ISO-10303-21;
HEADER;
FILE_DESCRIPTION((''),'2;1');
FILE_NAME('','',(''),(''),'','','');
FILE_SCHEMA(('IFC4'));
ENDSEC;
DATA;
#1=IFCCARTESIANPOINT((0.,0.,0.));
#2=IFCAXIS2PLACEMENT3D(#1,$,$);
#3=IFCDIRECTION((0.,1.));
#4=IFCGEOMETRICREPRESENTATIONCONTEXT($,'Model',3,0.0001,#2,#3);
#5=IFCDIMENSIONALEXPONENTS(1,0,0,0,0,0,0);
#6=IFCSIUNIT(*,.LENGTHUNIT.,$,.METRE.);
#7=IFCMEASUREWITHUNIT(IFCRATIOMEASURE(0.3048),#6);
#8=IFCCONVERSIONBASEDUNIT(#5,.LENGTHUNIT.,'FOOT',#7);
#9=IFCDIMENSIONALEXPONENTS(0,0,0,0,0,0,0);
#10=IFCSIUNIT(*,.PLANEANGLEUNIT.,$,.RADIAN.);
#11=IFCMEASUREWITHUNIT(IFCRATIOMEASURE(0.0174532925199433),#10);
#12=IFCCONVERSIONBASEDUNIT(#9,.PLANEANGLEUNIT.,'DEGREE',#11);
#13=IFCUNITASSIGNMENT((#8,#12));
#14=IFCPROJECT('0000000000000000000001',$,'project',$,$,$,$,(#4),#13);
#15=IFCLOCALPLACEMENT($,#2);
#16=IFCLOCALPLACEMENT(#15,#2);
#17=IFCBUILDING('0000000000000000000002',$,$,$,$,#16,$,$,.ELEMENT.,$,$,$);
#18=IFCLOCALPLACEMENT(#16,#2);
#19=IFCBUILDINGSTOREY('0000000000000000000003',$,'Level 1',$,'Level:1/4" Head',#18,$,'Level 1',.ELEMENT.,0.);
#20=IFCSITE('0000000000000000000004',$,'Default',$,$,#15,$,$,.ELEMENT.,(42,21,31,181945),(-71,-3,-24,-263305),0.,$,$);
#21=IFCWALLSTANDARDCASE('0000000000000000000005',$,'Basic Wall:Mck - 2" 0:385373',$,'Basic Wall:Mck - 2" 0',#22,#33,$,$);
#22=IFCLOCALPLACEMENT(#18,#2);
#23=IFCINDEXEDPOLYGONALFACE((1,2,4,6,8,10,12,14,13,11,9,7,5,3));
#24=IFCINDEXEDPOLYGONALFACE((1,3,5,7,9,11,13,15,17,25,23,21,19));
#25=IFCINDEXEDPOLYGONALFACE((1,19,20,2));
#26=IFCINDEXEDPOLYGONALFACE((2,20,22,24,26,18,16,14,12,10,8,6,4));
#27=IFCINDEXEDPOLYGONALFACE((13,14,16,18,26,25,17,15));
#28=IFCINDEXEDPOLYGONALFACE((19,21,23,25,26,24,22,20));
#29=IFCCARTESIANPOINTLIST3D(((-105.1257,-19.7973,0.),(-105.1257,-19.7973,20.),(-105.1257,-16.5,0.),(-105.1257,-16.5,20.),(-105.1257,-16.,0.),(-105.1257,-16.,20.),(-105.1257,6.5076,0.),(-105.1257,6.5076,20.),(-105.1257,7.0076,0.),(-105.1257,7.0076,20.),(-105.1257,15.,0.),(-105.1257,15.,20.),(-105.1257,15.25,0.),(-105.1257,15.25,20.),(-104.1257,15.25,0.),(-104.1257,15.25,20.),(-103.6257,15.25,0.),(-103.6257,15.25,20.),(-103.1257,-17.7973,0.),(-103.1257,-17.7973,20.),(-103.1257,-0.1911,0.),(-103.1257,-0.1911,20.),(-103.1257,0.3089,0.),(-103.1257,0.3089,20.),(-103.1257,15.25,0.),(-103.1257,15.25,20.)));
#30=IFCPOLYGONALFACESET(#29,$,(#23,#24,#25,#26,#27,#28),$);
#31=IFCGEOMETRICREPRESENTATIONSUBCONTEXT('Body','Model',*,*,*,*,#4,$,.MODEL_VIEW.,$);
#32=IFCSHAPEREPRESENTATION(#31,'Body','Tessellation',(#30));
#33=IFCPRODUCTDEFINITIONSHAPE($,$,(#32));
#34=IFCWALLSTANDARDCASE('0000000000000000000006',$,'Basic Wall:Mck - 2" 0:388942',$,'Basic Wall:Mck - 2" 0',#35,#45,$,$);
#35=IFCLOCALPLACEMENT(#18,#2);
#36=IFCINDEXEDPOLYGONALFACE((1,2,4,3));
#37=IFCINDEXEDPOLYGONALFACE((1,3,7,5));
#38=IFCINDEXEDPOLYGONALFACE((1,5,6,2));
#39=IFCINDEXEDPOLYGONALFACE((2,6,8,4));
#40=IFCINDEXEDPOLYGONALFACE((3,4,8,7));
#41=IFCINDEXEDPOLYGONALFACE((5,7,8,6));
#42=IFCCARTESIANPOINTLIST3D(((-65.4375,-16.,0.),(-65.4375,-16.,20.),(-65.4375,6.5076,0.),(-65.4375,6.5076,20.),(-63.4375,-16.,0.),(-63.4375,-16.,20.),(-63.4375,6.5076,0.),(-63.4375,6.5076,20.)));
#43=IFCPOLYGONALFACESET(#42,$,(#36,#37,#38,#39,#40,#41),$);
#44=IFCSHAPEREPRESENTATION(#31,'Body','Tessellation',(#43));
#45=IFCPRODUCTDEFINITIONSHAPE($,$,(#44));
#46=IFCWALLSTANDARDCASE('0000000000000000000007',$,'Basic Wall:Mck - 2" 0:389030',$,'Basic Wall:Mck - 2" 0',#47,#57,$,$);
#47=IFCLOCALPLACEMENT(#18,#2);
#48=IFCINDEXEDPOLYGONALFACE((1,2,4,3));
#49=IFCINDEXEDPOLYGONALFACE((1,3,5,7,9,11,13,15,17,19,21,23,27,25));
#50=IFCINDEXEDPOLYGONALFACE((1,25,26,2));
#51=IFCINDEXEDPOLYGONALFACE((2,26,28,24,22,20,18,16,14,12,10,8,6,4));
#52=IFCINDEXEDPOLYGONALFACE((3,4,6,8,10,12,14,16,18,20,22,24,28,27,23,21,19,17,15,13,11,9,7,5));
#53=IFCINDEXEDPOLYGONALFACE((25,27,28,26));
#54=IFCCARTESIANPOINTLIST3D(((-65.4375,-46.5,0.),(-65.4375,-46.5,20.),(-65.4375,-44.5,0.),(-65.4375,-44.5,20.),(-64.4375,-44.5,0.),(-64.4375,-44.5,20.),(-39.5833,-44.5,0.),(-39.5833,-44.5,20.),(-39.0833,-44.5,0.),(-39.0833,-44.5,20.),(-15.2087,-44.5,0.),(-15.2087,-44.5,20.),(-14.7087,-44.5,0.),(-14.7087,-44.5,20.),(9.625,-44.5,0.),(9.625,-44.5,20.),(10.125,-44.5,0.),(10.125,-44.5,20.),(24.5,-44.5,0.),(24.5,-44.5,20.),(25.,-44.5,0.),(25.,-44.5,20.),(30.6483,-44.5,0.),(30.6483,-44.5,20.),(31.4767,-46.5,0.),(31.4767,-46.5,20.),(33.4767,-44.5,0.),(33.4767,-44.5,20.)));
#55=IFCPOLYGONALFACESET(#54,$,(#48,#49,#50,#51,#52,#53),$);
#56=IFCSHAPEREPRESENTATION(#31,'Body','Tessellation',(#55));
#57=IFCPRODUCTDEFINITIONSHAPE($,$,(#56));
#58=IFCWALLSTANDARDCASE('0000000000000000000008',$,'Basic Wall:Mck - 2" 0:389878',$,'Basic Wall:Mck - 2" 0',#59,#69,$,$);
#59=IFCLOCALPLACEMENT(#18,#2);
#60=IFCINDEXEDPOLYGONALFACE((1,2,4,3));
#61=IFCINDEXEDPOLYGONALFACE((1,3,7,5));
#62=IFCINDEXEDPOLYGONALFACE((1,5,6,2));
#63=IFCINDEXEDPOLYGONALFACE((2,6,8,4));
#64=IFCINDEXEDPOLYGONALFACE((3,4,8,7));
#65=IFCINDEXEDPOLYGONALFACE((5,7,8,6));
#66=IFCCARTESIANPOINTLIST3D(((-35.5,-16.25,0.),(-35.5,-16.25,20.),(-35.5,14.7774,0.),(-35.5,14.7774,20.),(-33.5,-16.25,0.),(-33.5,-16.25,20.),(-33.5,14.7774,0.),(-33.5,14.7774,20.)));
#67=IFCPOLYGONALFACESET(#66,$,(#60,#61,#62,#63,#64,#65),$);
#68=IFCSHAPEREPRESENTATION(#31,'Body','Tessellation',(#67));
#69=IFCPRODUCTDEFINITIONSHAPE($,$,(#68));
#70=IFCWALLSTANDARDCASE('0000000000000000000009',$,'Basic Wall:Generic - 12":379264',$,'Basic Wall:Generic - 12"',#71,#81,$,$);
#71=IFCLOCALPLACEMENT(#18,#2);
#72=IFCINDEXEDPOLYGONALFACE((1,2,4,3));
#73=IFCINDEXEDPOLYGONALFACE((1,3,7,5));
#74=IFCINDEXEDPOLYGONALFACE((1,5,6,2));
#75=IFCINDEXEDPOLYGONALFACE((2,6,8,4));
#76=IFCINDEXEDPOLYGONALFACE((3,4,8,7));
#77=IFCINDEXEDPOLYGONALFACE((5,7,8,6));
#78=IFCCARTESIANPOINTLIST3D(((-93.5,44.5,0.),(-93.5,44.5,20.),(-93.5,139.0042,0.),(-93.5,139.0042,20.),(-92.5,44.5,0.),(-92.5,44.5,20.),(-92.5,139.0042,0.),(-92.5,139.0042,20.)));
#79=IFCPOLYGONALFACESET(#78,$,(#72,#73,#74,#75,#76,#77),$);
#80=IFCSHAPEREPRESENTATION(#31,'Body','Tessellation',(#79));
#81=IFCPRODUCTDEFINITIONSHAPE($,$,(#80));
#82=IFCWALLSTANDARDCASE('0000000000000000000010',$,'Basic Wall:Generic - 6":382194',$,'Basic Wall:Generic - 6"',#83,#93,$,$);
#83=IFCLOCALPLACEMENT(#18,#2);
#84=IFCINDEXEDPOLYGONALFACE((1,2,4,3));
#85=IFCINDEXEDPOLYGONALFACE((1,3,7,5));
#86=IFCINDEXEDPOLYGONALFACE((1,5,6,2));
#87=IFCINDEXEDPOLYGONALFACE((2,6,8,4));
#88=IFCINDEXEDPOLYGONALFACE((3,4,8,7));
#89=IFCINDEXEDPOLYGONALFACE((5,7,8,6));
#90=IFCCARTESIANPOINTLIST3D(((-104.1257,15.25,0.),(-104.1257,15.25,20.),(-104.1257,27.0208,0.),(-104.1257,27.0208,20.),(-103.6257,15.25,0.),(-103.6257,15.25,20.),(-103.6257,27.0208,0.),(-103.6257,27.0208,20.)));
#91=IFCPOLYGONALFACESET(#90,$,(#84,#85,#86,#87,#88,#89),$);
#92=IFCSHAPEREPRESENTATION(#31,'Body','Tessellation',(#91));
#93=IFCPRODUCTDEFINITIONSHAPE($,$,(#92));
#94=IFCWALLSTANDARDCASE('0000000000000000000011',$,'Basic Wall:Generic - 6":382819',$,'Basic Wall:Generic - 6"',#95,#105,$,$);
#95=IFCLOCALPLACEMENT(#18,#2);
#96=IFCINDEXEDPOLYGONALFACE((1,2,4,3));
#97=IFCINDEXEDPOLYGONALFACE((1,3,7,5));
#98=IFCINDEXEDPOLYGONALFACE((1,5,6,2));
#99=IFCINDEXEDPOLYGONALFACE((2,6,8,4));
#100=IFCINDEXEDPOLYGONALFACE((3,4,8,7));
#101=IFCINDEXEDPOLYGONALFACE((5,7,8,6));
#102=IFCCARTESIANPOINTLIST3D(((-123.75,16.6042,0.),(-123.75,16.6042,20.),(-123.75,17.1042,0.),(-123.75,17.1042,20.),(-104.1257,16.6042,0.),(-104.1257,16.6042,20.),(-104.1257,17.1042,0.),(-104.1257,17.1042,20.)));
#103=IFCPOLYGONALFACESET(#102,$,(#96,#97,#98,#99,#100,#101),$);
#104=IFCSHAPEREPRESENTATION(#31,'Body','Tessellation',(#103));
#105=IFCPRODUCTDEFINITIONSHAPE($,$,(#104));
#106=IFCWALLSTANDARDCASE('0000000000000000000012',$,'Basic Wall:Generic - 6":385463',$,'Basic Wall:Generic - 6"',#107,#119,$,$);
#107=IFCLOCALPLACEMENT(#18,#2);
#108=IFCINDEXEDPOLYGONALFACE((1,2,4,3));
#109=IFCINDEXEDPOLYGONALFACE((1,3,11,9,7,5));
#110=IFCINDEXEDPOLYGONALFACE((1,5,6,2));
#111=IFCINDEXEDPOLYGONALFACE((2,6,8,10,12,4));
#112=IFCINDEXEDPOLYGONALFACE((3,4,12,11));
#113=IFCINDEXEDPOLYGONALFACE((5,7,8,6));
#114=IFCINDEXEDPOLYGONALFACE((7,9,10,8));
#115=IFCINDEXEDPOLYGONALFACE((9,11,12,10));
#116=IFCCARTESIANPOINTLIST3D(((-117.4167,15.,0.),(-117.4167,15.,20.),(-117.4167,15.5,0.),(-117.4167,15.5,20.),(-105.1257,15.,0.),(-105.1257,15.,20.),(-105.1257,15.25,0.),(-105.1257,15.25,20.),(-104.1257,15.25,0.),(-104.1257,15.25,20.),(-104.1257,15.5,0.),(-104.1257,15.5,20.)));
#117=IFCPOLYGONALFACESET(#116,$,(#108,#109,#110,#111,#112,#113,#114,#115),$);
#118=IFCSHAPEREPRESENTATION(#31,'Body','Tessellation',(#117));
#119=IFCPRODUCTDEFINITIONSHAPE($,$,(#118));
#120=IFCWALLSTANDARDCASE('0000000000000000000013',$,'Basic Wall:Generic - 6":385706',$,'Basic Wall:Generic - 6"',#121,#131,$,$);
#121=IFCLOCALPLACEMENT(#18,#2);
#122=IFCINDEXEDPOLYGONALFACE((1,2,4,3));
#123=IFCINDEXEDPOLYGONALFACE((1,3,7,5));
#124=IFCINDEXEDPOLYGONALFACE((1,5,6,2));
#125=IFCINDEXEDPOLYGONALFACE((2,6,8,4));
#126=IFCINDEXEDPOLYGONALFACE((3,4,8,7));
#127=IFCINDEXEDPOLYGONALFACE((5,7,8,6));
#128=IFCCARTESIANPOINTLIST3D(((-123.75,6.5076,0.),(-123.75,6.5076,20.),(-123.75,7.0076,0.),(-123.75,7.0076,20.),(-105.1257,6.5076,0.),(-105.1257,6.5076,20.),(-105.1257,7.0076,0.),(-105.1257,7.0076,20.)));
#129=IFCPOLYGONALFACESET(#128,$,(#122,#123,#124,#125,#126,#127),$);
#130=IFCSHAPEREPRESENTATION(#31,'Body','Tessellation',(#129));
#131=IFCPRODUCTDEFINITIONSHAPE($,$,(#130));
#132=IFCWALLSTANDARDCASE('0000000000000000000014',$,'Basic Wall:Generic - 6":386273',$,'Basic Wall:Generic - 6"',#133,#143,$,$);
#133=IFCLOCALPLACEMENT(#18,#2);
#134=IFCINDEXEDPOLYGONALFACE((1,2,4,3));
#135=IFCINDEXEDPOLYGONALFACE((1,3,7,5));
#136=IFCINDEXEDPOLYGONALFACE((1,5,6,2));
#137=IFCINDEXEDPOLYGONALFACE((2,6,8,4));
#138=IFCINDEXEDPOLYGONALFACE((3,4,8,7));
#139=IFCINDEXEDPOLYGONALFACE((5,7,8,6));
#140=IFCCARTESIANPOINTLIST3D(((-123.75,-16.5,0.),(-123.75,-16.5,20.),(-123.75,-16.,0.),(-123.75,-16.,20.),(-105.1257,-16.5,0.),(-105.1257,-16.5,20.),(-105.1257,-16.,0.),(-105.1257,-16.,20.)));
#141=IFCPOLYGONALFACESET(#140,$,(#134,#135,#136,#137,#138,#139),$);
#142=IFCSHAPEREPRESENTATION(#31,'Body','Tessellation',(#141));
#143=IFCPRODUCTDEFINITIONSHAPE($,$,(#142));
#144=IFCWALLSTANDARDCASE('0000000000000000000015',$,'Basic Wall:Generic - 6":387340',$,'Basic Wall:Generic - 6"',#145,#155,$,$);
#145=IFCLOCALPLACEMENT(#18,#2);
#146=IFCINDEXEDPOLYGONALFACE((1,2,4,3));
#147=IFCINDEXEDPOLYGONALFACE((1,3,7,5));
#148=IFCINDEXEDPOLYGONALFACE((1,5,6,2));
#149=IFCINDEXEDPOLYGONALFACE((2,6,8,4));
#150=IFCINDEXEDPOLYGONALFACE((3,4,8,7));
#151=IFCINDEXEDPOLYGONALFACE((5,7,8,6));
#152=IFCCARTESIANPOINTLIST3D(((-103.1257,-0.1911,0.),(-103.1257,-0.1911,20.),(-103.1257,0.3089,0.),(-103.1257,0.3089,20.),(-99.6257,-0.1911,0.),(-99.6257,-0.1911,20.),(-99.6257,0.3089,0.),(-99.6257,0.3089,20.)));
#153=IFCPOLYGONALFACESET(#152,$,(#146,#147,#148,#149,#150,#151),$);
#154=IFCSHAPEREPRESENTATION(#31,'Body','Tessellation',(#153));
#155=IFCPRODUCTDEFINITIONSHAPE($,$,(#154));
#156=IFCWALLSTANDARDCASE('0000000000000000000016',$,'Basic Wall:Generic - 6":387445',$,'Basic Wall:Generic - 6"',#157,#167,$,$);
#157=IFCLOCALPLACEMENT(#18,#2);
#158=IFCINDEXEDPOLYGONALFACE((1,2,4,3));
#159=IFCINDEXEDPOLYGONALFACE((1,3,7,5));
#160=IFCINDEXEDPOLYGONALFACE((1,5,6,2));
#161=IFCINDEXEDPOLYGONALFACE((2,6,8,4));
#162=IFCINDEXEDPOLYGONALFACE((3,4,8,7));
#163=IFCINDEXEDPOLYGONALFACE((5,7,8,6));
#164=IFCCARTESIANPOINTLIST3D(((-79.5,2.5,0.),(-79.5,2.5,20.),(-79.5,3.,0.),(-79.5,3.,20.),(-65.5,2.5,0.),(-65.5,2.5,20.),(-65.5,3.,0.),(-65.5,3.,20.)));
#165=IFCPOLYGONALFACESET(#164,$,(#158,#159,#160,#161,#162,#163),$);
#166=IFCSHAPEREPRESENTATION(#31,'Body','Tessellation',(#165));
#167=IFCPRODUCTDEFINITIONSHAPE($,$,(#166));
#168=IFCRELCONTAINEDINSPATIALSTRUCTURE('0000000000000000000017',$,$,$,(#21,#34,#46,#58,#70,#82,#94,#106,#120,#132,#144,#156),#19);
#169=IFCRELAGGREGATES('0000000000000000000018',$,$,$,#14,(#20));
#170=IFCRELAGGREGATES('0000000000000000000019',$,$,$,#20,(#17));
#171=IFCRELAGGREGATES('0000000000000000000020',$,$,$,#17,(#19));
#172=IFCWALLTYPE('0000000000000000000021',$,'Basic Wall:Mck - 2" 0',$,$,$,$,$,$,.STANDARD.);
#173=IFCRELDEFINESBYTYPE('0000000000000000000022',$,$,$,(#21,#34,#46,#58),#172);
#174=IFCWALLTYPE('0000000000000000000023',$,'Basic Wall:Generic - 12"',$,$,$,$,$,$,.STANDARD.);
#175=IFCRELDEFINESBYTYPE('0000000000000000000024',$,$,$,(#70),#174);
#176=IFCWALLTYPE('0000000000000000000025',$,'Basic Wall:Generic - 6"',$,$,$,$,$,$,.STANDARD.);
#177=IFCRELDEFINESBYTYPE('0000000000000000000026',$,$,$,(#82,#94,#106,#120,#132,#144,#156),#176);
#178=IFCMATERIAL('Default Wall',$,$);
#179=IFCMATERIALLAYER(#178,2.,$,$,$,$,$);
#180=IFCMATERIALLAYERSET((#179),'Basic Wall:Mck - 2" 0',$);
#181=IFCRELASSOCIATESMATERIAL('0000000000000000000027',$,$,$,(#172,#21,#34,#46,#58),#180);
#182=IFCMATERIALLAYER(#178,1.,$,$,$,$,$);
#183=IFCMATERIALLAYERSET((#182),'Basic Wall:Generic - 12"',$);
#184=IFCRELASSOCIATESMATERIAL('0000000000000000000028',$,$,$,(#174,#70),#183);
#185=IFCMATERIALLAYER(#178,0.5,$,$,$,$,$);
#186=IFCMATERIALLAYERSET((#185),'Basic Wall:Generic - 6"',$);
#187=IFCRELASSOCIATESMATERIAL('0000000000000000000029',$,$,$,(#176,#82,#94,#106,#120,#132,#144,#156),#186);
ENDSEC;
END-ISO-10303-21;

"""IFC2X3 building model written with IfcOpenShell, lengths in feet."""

from ifc_helpers import new_model, entity, si_unit, converted_unit, direction, frame, frame_2d, origin, place, context, subcontext, project, spatial, polyline, rectangle, outline, extrude, material, layer, layer_set, layer_usage, type_object, element, save


model = new_model("IFC2X3")

# Units and contexts
model_context = context("Model", 3, precision=0.0001, world=origin(), true_north=direction((0.0, 1.0)))
body_context = subcontext(model_context, "Body", "Model", "MODEL_VIEW")
ifc_project = project(units=[converted_unit("LENGTHUNIT", "FOOT", entity("IfcRatioMeasure", 0.3048), si_unit("LENGTHUNIT", "METRE"), dimensions=[1, 0, 0, 0, 0, 0, 0]), converted_unit("PLANEANGLEUNIT", "DEGREE", entity("IfcRatioMeasure", 0.0174532925199433), si_unit("PLANEANGLEUNIT", "RADIAN"), dimensions=[0, 0, 0, 0, 0, 0, 0])], contexts=[model_context])

# Site, building, storey
site_placement = place(None, origin())
site = spatial("IfcSite", under=ifc_project, at=site_placement, Name="Default", CompositionType="ELEMENT", RefLatitude=(42, 21, 31, 181945), RefLongitude=(-71, -3, -24, -263305), RefElevation=0.0)
building_placement = place(site_placement, origin())
building = spatial("IfcBuilding", under=site, at=building_placement, CompositionType="ELEMENT")
storey_placement = place(building_placement, origin())
storey = spatial("IfcBuildingStorey", under=building, at=storey_placement, Name="Level 1", ObjectType="Level:1/4\" Head", LongName="Level 1", CompositionType="ELEMENT", Elevation=0.0)

# Walls
ifc_material = material(Name="Default Wall")
ifc_layer_1 = layer(ifc_material, 2.0)
ifc_layer_set_1 = layer_set([ifc_layer_1], Name="Basic Wall:Mck - 2\" 0")
ifc_layer_usage_1 = layer_usage(ifc_layer_set_1, "AXIS2", "NEGATIVE", 1.0)
wall_type_1 = type_object("IfcWallType", Name="Basic Wall:Mck - 2\" 0", PredefinedType="STANDARD", material=ifc_layer_set_1)
wall_1_placement = place(storey_placement, frame((-104.1257, 15.25, 0.0), z_axis=(0.0, 0.0, 1.0), x_axis=(0.0, -1.0, 0.0)))
element("IfcWallStandardCase", 1, at=wall_1_placement, inside=storey, type_object=wall_type_1, material=ifc_layer_usage_1, Name="Basic Wall:Mck - 2\" 0:385373", ObjectType="Basic Wall:Mck - 2\" 0", context=body_context, shape_type="SweptSolid", body=[
    extrude(outline(polyline([(35.0473, -1.0), (33.0473, 1.0), (15.4411, 1.0), (14.9411, 1.0), (0.0, 1.0), (0.0, 0.5), (0.0, 0.0), (0.0, -1.0), (0.25, -1.0), (8.2424, -1.0), (8.7424, -1.0), (31.25, -1.0), (31.75, -1.0), (35.0473, -1.0)])), origin(), (0.0, 0.0, 1.0), 20.0),
])
ifc_layer_usage_2 = layer_usage(ifc_layer_set_1, "AXIS2", "NEGATIVE", 1.0)
wall_2_placement = place(storey_placement, frame((-64.4375, 6.5076, 0.0), z_axis=(0.0, 0.0, 1.0), x_axis=(0.0, -1.0, 0.0)))
element("IfcWallStandardCase", 2, at=wall_2_placement, inside=storey, type_object=wall_type_1, material=ifc_layer_usage_2, Name="Basic Wall:Mck - 2\" 0:388942", ObjectType="Basic Wall:Mck - 2\" 0", context=body_context, shape_type="SweptSolid", body=[
    extrude(rectangle(XDim=22.5076, YDim=2.0, at=frame_2d((11.2538, 0.0), x_axis=(-1.0, 0.0))), origin(), (0.0, 0.0, 1.0), 20.0),
])
ifc_layer_usage_3 = layer_usage(ifc_layer_set_1, "AXIS2", "NEGATIVE", 1.0)
wall_3_placement = place(storey_placement, frame((-65.4375, -45.5, 0.0)))
element("IfcWallStandardCase", 3, at=wall_3_placement, inside=storey, type_object=wall_type_1, material=ifc_layer_usage_3, Name="Basic Wall:Mck - 2\" 0:389030", ObjectType="Basic Wall:Mck - 2\" 0", context=body_context, shape_type="SweptSolid", body=[
    extrude(outline(polyline([(96.9142, -1.0), (98.9142, 1.0), (96.0858, 1.0), (90.4375, 1.0), (89.9375, 1.0), (75.5625, 1.0), (75.0625, 1.0), (50.7288, 1.0), (50.2288, 1.0), (26.3542, 1.0), (25.8542, 1.0), (1.0, 1.0), (0.0, 1.0), (0.0, -1.0), (96.9142, -1.0)])), origin(), (0.0, 0.0, 1.0), 20.0),
])
ifc_layer_usage_4 = layer_usage(ifc_layer_set_1, "AXIS2", "NEGATIVE", 1.0)
wall_4_placement = place(storey_placement, frame((-34.5, 14.7774, 0.0), z_axis=(0.0, 0.0, 1.0), x_axis=(0.0, -1.0, 0.0)))
element("IfcWallStandardCase", 4, at=wall_4_placement, inside=storey, type_object=wall_type_1, material=ifc_layer_usage_4, Name="Basic Wall:Mck - 2\" 0:389878", ObjectType="Basic Wall:Mck - 2\" 0", context=body_context, shape_type="SweptSolid", body=[
    extrude(rectangle(XDim=31.0274, YDim=2.0, at=frame_2d((15.5137, 0.0), x_axis=(-1.0, 0.0))), origin(), (0.0, 0.0, 1.0), 20.0),
])
ifc_layer_2 = layer(ifc_material, 1.0)
ifc_layer_set_2 = layer_set([ifc_layer_2], Name="Basic Wall:Generic - 12\"")
ifc_layer_usage_5 = layer_usage(ifc_layer_set_2, "AXIS2", "NEGATIVE", 0.5)
wall_type_2 = type_object("IfcWallType", Name="Basic Wall:Generic - 12\"", PredefinedType="STANDARD", material=ifc_layer_set_2)
wall_5_placement = place(storey_placement, frame((-93.0, 44.5, 0.0), z_axis=(0.0, 0.0, 1.0), x_axis=(0.0, 1.0, 0.0)))
element("IfcWallStandardCase", 5, at=wall_5_placement, inside=storey, type_object=wall_type_2, material=ifc_layer_usage_5, Name="Basic Wall:Generic - 12\":379264", ObjectType="Basic Wall:Generic - 12\"", context=body_context, shape_type="SweptSolid", body=[
    extrude(rectangle(XDim=94.5042, YDim=1.0, at=frame_2d((47.2521, 0.0), x_axis=(-1.0, 0.0))), origin(), (0.0, 0.0, 1.0), 20.0),
])
ifc_layer_3 = layer(ifc_material, 0.5)
ifc_layer_set_3 = layer_set([ifc_layer_3], Name="Basic Wall:Generic - 6\"")
ifc_layer_usage_6 = layer_usage(ifc_layer_set_3, "AXIS2", "NEGATIVE", 0.25)
wall_type_3 = type_object("IfcWallType", Name="Basic Wall:Generic - 6\"", PredefinedType="STANDARD", material=ifc_layer_set_3)
wall_6_placement = place(storey_placement, frame((-103.8757, 27.0208, 0.0), z_axis=(0.0, 0.0, 1.0), x_axis=(0.0, -1.0, 0.0)))
element("IfcWallStandardCase", 6, at=wall_6_placement, inside=storey, type_object=wall_type_3, material=ifc_layer_usage_6, Name="Basic Wall:Generic - 6\":382194", ObjectType="Basic Wall:Generic - 6\"", context=body_context, shape_type="SweptSolid", body=[
    extrude(rectangle(XDim=11.7708, YDim=0.5, at=frame_2d((5.8854, 0.0), x_axis=(-1.0, 0.0))), origin(), (0.0, 0.0, 1.0), 20.0),
])
ifc_layer_usage_7 = layer_usage(ifc_layer_set_3, "AXIS2", "NEGATIVE", 0.25)
wall_7_placement = place(storey_placement, frame((-104.1257, 16.8542, 0.0), z_axis=(0.0, 0.0, 1.0), x_axis=(-1.0, 0.0, 0.0)))
element("IfcWallStandardCase", 7, at=wall_7_placement, inside=storey, type_object=wall_type_3, material=ifc_layer_usage_7, Name="Basic Wall:Generic - 6\":382819", ObjectType="Basic Wall:Generic - 6\"", context=body_context, shape_type="SweptSolid", body=[
    extrude(rectangle(XDim=19.6243, YDim=0.5, at=frame_2d((9.8122, 0.0), x_axis=(-1.0, 0.0))), origin(), (0.0, 0.0, 1.0), 20.0),
])
ifc_layer_usage_8 = layer_usage(ifc_layer_set_3, "AXIS2", "NEGATIVE", 0.25)
wall_8_placement = place(storey_placement, frame((-104.1257, 15.25, 0.0), z_axis=(0.0, 0.0, 1.0), x_axis=(-1.0, 0.0, 0.0)))
element("IfcWallStandardCase", 8, at=wall_8_placement, inside=storey, type_object=wall_type_3, material=ifc_layer_usage_8, Name="Basic Wall:Generic - 6\":385463", ObjectType="Basic Wall:Generic - 6\"", context=body_context, shape_type="SweptSolid", body=[
    extrude(outline(polyline([(13.291, -0.25), (13.291, 0.25), (1.0, 0.25), (1.0, 0.0), (0.0, 0.0), (0.0, -0.25), (13.291, -0.25)])), origin(), (0.0, 0.0, 1.0), 20.0),
])
ifc_layer_usage_9 = layer_usage(ifc_layer_set_3, "AXIS2", "NEGATIVE", 0.25)
wall_9_placement = place(storey_placement, frame((-105.1257, 6.7576, 0.0), z_axis=(0.0, 0.0, 1.0), x_axis=(-1.0, 0.0, 0.0)))
element("IfcWallStandardCase", 9, at=wall_9_placement, inside=storey, type_object=wall_type_3, material=ifc_layer_usage_9, Name="Basic Wall:Generic - 6\":385706", ObjectType="Basic Wall:Generic - 6\"", context=body_context, shape_type="SweptSolid", body=[
    extrude(rectangle(XDim=18.6243, YDim=0.5, at=frame_2d((9.3122, 0.0), x_axis=(-1.0, 0.0))), origin(), (0.0, 0.0, 1.0), 20.0),
])
ifc_layer_usage_10 = layer_usage(ifc_layer_set_3, "AXIS2", "NEGATIVE", 0.25)
wall_10_placement = place(storey_placement, frame((-105.1257, -16.25, 0.0), z_axis=(0.0, 0.0, 1.0), x_axis=(-1.0, 0.0, 0.0)))
element("IfcWallStandardCase", 10, at=wall_10_placement, inside=storey, type_object=wall_type_3, material=ifc_layer_usage_10, Name="Basic Wall:Generic - 6\":386273", ObjectType="Basic Wall:Generic - 6\"", context=body_context, shape_type="SweptSolid", body=[
    extrude(rectangle(XDim=18.6243, YDim=0.5, at=frame_2d((9.3122, 0.0), x_axis=(-1.0, 0.0))), origin(), (0.0, 0.0, 1.0), 20.0),
])
ifc_layer_usage_11 = layer_usage(ifc_layer_set_3, "AXIS2", "NEGATIVE", 0.25)
wall_11_placement = place(storey_placement, frame((-103.1257, 0.0589, 0.0)))
element("IfcWallStandardCase", 11, at=wall_11_placement, inside=storey, type_object=wall_type_3, material=ifc_layer_usage_11, Name="Basic Wall:Generic - 6\":387340", ObjectType="Basic Wall:Generic - 6\"", context=body_context, shape_type="SweptSolid", body=[
    extrude(rectangle(XDim=3.5, YDim=0.5, at=frame_2d((1.75, 0.0), x_axis=(-1.0, 0.0))), origin(), (0.0, 0.0, 1.0), 20.0),
])
ifc_layer_usage_12 = layer_usage(ifc_layer_set_3, "AXIS2", "NEGATIVE", 0.25)
wall_12_placement = place(storey_placement, frame((-79.5, 2.75, 0.0)))
element("IfcWallStandardCase", 12, at=wall_12_placement, inside=storey, type_object=wall_type_3, material=ifc_layer_usage_12, Name="Basic Wall:Generic - 6\":387445", ObjectType="Basic Wall:Generic - 6\"", context=body_context, shape_type="SweptSolid", body=[
    extrude(rectangle(XDim=14.0, YDim=0.5, at=frame_2d((7.0, 0.0), x_axis=(-1.0, 0.0))), origin(), (0.0, 0.0, 1.0), 20.0),
])

save(model, "model.ifc")
